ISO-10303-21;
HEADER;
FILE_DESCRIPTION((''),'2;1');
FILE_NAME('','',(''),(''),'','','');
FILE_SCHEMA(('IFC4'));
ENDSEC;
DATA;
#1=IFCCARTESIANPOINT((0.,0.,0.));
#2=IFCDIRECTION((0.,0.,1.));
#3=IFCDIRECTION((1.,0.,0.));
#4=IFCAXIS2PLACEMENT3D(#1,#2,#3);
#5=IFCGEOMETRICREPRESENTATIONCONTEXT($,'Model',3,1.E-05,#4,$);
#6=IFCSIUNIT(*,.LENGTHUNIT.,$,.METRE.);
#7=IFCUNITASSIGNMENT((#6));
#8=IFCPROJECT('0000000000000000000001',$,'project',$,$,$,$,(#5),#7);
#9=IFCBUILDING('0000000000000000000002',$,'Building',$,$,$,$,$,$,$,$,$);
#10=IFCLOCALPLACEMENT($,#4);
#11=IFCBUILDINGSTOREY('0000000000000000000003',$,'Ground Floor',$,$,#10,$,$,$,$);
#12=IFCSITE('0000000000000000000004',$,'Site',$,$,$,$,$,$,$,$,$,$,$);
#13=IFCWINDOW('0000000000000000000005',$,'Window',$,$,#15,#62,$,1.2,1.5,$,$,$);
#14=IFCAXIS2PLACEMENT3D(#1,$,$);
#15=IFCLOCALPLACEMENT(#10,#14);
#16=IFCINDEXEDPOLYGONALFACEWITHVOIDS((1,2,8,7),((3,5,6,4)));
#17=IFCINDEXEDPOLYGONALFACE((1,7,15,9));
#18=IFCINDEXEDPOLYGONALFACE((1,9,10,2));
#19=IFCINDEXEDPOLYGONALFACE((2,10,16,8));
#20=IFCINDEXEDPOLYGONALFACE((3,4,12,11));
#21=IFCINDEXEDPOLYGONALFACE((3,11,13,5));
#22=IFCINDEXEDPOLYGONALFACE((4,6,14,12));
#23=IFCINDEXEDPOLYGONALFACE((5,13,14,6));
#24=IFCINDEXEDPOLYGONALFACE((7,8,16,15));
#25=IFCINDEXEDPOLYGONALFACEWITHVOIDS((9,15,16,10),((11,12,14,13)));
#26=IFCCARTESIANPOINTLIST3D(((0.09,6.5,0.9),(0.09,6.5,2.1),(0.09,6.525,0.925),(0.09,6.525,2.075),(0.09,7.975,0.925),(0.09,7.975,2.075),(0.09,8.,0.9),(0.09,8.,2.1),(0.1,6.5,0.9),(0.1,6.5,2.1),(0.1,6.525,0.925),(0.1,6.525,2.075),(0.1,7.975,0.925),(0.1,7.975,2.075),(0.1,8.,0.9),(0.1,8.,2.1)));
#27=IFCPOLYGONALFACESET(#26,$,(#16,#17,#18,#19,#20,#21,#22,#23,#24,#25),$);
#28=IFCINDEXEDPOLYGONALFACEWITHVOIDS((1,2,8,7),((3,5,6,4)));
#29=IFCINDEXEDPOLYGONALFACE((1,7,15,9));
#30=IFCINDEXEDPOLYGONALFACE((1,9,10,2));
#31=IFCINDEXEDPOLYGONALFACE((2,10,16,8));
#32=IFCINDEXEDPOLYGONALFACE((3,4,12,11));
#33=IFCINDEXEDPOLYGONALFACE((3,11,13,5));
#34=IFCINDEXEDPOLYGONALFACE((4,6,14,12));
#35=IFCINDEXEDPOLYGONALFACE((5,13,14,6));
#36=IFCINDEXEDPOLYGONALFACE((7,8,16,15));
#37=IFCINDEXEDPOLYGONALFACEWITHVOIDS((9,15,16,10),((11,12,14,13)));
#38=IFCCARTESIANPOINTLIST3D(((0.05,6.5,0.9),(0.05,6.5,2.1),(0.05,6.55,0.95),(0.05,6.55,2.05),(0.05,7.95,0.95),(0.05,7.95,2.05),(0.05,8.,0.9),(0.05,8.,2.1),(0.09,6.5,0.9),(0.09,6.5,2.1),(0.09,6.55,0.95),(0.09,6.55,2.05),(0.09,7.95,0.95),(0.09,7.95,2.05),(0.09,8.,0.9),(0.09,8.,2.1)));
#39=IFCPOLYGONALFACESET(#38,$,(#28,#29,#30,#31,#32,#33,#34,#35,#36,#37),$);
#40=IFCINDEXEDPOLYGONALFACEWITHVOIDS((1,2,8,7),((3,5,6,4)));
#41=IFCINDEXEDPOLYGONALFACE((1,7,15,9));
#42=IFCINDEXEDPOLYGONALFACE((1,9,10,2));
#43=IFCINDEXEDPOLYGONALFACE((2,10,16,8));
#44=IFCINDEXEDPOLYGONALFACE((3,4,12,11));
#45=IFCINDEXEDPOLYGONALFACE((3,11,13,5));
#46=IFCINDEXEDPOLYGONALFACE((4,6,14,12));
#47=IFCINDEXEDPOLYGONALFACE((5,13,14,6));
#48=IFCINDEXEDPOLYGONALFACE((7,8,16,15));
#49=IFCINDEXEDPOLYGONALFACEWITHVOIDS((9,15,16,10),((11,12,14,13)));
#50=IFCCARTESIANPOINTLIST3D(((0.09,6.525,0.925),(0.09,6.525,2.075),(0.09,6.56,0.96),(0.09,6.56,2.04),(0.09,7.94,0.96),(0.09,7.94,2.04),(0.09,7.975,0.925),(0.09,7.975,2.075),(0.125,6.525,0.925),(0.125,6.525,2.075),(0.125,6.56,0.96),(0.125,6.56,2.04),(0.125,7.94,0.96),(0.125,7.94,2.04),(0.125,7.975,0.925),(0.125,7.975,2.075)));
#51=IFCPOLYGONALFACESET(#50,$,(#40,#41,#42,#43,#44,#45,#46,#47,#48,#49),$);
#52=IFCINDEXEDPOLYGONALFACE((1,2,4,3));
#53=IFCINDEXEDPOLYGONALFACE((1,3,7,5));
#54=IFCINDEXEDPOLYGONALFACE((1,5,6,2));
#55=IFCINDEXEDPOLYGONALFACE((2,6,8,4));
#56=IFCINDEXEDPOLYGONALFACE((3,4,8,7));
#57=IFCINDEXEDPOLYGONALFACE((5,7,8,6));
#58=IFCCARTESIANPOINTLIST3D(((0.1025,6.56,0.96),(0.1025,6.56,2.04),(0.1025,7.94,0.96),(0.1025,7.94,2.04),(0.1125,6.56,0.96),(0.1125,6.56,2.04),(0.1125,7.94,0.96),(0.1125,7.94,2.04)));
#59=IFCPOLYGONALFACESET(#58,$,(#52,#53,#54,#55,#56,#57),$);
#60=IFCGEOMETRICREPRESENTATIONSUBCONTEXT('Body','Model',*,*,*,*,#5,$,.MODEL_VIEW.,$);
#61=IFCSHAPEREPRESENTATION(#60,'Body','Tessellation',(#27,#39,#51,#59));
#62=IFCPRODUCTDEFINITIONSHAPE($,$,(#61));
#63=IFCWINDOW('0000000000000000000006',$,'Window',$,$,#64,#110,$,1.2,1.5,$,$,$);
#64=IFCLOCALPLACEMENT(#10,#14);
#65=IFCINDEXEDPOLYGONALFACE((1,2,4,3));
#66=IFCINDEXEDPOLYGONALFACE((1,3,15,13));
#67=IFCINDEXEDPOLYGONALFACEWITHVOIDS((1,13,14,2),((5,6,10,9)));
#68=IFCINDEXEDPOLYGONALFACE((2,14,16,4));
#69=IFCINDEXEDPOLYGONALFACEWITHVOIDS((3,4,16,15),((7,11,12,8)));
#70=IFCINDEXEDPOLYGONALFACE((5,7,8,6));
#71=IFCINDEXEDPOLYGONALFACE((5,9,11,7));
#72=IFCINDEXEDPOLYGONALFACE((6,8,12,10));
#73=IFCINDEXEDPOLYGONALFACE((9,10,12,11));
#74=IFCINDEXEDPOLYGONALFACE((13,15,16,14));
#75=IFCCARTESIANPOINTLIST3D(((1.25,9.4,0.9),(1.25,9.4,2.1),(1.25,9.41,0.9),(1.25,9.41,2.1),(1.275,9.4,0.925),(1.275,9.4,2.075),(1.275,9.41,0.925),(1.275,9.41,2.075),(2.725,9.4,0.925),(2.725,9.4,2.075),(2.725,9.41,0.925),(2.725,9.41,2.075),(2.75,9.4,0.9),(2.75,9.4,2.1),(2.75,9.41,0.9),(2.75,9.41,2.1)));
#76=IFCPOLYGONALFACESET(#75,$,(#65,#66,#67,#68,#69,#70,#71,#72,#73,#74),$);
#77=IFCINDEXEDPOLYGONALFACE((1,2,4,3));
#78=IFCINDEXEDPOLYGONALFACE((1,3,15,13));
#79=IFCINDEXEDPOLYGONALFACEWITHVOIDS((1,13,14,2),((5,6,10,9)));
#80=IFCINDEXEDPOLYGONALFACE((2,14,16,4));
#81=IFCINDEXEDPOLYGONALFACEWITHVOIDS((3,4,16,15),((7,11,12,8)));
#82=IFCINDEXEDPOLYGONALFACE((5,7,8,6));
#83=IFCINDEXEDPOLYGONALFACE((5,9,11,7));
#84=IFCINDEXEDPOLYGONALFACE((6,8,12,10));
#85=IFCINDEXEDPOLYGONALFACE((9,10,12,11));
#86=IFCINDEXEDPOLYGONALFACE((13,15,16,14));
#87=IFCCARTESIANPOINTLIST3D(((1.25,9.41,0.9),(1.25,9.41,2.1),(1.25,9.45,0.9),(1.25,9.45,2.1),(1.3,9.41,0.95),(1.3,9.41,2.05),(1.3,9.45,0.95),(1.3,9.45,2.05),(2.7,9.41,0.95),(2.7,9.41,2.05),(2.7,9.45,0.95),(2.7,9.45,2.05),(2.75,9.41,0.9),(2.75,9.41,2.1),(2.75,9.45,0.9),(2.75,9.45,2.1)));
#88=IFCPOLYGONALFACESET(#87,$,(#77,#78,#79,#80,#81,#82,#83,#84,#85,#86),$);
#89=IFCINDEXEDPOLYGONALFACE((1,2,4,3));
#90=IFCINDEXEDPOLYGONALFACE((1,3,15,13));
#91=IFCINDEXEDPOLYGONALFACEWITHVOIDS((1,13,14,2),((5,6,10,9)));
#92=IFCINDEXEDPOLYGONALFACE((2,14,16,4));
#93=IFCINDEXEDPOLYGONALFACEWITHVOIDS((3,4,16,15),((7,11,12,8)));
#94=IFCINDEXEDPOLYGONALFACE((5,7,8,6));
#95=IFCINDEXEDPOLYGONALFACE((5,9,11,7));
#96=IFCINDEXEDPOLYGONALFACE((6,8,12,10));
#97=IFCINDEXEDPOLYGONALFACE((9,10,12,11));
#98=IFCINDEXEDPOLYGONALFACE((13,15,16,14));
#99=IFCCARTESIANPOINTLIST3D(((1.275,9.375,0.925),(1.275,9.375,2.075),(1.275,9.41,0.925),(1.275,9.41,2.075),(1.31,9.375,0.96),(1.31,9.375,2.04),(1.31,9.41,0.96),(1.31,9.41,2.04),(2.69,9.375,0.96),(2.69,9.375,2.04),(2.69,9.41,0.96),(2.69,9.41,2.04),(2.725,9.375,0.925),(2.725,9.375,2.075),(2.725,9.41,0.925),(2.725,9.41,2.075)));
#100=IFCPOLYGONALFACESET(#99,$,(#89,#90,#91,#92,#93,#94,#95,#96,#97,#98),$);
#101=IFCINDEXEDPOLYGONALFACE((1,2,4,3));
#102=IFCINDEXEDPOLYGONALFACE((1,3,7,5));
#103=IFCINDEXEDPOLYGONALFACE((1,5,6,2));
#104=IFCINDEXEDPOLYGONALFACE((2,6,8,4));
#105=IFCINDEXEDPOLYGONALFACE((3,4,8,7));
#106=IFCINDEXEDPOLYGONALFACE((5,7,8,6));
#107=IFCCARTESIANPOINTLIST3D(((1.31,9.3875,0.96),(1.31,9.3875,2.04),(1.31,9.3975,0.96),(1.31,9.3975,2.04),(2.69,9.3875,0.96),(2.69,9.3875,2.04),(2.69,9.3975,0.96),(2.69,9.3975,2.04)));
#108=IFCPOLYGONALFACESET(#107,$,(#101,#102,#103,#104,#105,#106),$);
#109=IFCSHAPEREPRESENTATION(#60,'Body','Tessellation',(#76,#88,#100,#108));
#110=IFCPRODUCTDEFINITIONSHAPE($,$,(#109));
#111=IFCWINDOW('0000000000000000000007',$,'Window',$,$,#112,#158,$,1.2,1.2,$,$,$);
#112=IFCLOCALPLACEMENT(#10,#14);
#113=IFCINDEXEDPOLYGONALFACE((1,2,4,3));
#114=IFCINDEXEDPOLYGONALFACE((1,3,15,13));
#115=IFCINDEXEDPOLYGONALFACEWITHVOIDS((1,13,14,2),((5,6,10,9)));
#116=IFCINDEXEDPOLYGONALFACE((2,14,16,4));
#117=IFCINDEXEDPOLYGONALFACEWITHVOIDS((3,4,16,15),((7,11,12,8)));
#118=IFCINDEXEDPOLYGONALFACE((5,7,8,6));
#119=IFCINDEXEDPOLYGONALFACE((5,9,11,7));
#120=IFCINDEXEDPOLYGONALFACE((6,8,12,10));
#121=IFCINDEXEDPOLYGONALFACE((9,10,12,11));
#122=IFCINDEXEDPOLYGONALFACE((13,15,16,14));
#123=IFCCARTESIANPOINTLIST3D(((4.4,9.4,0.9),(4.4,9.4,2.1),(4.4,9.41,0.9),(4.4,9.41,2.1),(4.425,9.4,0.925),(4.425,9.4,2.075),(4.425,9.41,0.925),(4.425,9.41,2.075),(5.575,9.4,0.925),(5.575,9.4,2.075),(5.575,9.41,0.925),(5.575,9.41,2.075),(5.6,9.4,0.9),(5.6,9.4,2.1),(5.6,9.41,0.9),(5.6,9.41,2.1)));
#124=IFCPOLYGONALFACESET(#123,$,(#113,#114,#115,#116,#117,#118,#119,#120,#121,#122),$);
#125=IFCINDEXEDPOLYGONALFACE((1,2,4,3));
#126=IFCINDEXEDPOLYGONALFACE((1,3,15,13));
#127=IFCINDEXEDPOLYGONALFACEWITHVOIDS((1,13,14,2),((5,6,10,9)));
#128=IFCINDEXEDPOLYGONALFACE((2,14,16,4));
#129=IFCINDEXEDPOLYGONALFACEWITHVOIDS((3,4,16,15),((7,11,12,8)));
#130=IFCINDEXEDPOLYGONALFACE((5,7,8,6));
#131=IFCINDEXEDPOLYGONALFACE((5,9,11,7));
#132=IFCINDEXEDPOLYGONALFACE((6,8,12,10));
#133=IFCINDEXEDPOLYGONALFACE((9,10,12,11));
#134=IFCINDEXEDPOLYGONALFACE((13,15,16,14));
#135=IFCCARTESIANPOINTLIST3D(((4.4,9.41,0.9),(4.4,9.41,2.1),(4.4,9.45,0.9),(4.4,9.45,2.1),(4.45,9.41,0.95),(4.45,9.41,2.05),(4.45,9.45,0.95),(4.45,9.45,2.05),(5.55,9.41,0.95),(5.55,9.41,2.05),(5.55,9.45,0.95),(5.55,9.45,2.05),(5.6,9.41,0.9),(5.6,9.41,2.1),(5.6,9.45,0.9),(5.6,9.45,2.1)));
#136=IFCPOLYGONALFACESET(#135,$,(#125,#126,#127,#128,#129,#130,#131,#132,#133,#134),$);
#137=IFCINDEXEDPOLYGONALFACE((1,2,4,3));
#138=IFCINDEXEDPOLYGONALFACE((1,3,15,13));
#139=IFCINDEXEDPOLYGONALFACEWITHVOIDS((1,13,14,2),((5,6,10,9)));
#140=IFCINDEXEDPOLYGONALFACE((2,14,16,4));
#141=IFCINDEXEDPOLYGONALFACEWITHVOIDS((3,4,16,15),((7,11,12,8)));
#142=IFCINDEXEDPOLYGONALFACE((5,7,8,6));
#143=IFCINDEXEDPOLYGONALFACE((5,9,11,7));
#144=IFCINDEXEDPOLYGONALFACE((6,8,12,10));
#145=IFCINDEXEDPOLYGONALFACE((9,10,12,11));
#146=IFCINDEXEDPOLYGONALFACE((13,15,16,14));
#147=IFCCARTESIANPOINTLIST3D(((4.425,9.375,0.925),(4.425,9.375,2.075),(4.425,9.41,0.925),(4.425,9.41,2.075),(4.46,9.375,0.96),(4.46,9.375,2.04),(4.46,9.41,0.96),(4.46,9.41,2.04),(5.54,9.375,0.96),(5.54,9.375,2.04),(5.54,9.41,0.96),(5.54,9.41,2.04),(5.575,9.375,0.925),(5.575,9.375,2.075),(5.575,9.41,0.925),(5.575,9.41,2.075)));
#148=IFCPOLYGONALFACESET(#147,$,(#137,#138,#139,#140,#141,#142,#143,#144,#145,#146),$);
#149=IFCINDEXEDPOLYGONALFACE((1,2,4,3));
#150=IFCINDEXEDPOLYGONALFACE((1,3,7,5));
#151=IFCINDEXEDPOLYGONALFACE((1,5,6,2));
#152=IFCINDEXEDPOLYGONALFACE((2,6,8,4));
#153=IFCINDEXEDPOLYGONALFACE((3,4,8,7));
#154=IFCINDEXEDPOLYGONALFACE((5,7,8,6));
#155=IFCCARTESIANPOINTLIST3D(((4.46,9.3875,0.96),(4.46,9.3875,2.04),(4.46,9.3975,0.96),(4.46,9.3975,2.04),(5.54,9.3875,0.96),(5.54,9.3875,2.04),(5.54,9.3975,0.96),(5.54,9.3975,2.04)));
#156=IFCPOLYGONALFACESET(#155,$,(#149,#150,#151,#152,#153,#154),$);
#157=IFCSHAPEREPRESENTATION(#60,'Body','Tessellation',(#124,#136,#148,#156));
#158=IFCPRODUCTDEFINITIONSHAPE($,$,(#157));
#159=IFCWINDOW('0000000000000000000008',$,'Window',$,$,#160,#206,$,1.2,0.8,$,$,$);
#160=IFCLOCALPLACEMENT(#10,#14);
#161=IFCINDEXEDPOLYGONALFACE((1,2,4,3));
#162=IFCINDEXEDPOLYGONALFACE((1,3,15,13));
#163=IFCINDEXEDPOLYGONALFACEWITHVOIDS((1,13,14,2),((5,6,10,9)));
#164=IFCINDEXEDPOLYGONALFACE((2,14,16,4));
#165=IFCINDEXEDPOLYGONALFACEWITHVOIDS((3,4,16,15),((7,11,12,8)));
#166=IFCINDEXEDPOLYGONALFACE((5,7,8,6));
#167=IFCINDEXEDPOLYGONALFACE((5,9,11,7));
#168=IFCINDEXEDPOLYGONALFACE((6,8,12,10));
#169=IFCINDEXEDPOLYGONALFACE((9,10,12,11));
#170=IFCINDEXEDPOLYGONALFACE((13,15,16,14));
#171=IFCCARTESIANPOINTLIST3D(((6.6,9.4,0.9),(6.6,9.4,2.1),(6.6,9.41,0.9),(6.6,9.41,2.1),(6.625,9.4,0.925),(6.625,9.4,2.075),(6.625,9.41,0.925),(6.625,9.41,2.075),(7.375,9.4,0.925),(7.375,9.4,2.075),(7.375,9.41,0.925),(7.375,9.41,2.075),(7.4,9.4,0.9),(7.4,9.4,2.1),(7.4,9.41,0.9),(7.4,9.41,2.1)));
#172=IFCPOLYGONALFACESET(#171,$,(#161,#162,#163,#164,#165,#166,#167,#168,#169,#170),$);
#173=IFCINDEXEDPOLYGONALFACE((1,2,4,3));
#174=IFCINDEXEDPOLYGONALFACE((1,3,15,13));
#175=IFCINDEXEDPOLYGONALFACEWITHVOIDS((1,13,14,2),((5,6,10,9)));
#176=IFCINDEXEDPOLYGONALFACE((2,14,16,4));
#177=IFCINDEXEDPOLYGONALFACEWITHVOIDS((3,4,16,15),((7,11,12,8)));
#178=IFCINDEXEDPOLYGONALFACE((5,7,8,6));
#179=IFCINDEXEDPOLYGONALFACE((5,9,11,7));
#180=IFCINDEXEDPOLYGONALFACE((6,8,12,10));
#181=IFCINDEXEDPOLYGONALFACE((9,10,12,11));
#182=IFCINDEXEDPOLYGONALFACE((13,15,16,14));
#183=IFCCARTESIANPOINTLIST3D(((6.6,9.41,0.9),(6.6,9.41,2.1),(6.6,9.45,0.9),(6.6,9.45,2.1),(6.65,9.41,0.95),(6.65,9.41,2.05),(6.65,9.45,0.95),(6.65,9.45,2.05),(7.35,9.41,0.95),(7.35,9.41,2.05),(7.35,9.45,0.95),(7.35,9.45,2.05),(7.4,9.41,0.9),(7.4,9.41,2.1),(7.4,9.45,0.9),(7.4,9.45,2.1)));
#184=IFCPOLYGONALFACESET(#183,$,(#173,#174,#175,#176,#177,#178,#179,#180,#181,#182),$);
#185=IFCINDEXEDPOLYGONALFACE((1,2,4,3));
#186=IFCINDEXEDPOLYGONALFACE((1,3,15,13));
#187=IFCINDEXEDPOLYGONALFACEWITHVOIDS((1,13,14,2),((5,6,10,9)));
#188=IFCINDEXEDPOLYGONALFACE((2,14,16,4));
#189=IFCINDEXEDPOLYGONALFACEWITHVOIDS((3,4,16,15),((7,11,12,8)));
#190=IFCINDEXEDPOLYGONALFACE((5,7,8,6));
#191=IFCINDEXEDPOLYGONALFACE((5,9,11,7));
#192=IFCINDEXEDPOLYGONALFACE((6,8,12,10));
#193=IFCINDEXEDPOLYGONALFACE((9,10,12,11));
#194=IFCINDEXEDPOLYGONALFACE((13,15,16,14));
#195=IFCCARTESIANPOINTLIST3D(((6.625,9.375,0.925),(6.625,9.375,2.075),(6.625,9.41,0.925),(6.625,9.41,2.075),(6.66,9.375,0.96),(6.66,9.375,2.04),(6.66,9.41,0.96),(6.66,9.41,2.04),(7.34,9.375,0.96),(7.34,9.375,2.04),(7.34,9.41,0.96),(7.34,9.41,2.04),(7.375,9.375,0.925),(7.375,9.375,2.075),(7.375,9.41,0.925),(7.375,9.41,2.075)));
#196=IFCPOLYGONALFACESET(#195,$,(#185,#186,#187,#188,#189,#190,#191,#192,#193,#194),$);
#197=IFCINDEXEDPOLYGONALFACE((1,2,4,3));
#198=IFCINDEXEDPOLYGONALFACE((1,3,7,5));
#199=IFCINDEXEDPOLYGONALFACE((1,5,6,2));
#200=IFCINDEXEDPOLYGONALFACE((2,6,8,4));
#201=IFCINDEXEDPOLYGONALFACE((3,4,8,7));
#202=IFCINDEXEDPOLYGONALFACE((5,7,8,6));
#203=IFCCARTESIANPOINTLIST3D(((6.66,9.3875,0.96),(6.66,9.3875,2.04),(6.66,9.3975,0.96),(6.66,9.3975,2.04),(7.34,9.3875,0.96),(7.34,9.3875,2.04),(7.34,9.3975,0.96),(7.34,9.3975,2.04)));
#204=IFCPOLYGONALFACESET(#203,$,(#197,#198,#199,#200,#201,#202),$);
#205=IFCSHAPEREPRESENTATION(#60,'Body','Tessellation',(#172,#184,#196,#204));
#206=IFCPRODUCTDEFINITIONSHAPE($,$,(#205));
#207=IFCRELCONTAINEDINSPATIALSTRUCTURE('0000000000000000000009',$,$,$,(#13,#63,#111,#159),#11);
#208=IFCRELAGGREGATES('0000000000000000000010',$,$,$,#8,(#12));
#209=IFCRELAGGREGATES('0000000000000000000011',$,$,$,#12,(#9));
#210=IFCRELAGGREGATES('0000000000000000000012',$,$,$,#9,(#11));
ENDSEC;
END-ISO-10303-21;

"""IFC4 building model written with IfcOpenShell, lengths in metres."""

from ifc_helpers import new_model, si_unit, frame, origin_with_axes, place, context, subcontext, project, spatial, line, indexed_curve, outline, extrude, element, save


model = new_model("IFC4")

# Units and contexts
model_context = context("Model", 3, precision=1e-05, world=origin_with_axes())
body_context = subcontext(model_context, "Body", "Model", "MODEL_VIEW")
ifc_project = project(units=[si_unit("LENGTHUNIT", "METRE")], contexts=[model_context])

# Site, building, storey
site = spatial("IfcSite", under=ifc_project, Name="Site")
building = spatial("IfcBuilding", under=site, Name="Building")
storey_placement = place(None, origin_with_axes())
storey = spatial("IfcBuildingStorey", under=building, at=storey_placement, Name="Ground Floor")

# Windows
for number, where, z_axis, x_axis, name in (
    (1, (0.0, 8.0, 0.9), (0.0, 0.0, 1.0), (0.0, -1.0, 0.0), "Window"),
    (2, (2.75, 9.5, 0.9), (0.0, 0.0, 1.0), (-1.0, 0.0, 0.0), "Window"),
):
    element("IfcWindow", number, at=place(storey_placement, frame(where, z_axis=z_axis, x_axis=x_axis)), inside=storey, Name=name, OverallHeight=1.2, OverallWidth=1.5, context=body_context, shape_type="SweptSolid", body=[
        extrude(outline(indexed_curve([(0.0, 0.0), (1.5, 0.0), (1.5, 1.2), (0.0, 1.2)], segments=[line(1, 2, 3, 4, 1)]), holes=[indexed_curve([(0.025, 0.025), (1.475, 0.025), (1.475, 1.175), (0.025, 1.175)], segments=[line(1, 2, 3, 4, 1)])]), frame((0.0, 0.09, 0.0), z_axis=(0.0, -1.0, 0.0), x_axis=(1.0, 0.0, 0.0)), (0.0, 0.0, -1.0), 0.01),
        extrude(outline(indexed_curve([(0.0, 0.0), (1.5, 0.0), (1.5, 1.2), (0.0, 1.2)], segments=[line(1, 2, 3, 4, 1)]), holes=[indexed_curve([(0.05, 0.05), (1.45, 0.05), (1.45, 1.15), (0.05, 1.15)], segments=[line(1, 2, 3, 4, 1)])]), frame((0.0, 0.05, 0.0), z_axis=(0.0, -1.0, 0.0), x_axis=(1.0, 0.0, 0.0)), (0.0, 0.0, -1.0), 0.04),
        extrude(outline(indexed_curve([(0.0, 0.0), (1.45, 0.0), (1.45, 1.15), (0.0, 1.15)], segments=[line(1, 2, 3, 4, 1)]), holes=[indexed_curve([(0.035, 0.035), (1.415, 0.035), (1.415, 1.115), (0.035, 1.115)], segments=[line(1, 2, 3, 4, 1)])]), frame((0.025, 0.09, 0.025), z_axis=(0.0, -1.0, 0.0), x_axis=(1.0, 0.0, 0.0)), (0.0, 0.0, -1.0), 0.035),
        extrude(outline(indexed_curve([(0.035, 0.035), (1.415, 0.035), (1.415, 1.115), (0.035, 1.115)], segments=[line(1, 2, 3, 4, 1)])), frame((0.025, 0.1025, 0.025), z_axis=(0.0, -1.0, 0.0), x_axis=(1.0, 0.0, 0.0)), (0.0, 0.0, -1.0), 0.01),
    ])
window_1_placement = place(storey_placement, frame((5.6, 9.5, 0.9), z_axis=(0.0, 0.0, 1.0), x_axis=(-1.0, 0.0, 0.0)))
element("IfcWindow", 3, at=window_1_placement, inside=storey, Name="Window", OverallHeight=1.2, OverallWidth=1.2, context=body_context, shape_type="SweptSolid", body=[
    extrude(outline(indexed_curve([(0.0, 0.0), (1.2, 0.0), (1.2, 1.2), (0.0, 1.2)], segments=[line(1, 2, 3, 4, 1)]), holes=[indexed_curve([(0.025, 0.025), (1.175, 0.025), (1.175, 1.175), (0.025, 1.175)], segments=[line(1, 2, 3, 4, 1)])]), frame((0.0, 0.09, 0.0), z_axis=(0.0, -1.0, 0.0), x_axis=(1.0, 0.0, 0.0)), (0.0, 0.0, -1.0), 0.01),
    extrude(outline(indexed_curve([(0.0, 0.0), (1.2, 0.0), (1.2, 1.2), (0.0, 1.2)], segments=[line(1, 2, 3, 4, 1)]), holes=[indexed_curve([(0.05, 0.05), (1.15, 0.05), (1.15, 1.15), (0.05, 1.15)], segments=[line(1, 2, 3, 4, 1)])]), frame((0.0, 0.05, 0.0), z_axis=(0.0, -1.0, 0.0), x_axis=(1.0, 0.0, 0.0)), (0.0, 0.0, -1.0), 0.04),
    extrude(outline(indexed_curve([(0.0, 0.0), (1.15, 0.0), (1.15, 1.15), (0.0, 1.15)], segments=[line(1, 2, 3, 4, 1)]), holes=[indexed_curve([(0.035, 0.035), (1.115, 0.035), (1.115, 1.115), (0.035, 1.115)], segments=[line(1, 2, 3, 4, 1)])]), frame((0.025, 0.09, 0.025), z_axis=(0.0, -1.0, 0.0), x_axis=(1.0, 0.0, 0.0)), (0.0, 0.0, -1.0), 0.035),
    extrude(outline(indexed_curve([(0.035, 0.035), (1.115, 0.035), (1.115, 1.115), (0.035, 1.115)], segments=[line(1, 2, 3, 4, 1)])), frame((0.025, 0.1025, 0.025), z_axis=(0.0, -1.0, 0.0), x_axis=(1.0, 0.0, 0.0)), (0.0, 0.0, -1.0), 0.01),
])
window_2_placement = place(storey_placement, frame((7.4, 9.5, 0.9), z_axis=(0.0, 0.0, 1.0), x_axis=(-1.0, 0.0, 0.0)))
element("IfcWindow", 4, at=window_2_placement, inside=storey, Name="Window", OverallHeight=1.2, OverallWidth=0.8, context=body_context, shape_type="SweptSolid", body=[
    extrude(outline(indexed_curve([(0.0, 0.0), (0.8, 0.0), (0.8, 1.2), (0.0, 1.2)], segments=[line(1, 2, 3, 4, 1)]), holes=[indexed_curve([(0.025, 0.025), (0.775, 0.025), (0.775, 1.175), (0.025, 1.175)], segments=[line(1, 2, 3, 4, 1)])]), frame((0.0, 0.09, 0.0), z_axis=(0.0, -1.0, 0.0), x_axis=(1.0, 0.0, 0.0)), (0.0, 0.0, -1.0), 0.01),
    extrude(outline(indexed_curve([(0.0, 0.0), (0.8, 0.0), (0.8, 1.2), (0.0, 1.2)], segments=[line(1, 2, 3, 4, 1)]), holes=[indexed_curve([(0.05, 0.05), (0.75, 0.05), (0.75, 1.15), (0.05, 1.15)], segments=[line(1, 2, 3, 4, 1)])]), frame((0.0, 0.05, 0.0), z_axis=(0.0, -1.0, 0.0), x_axis=(1.0, 0.0, 0.0)), (0.0, 0.0, -1.0), 0.04),
    extrude(outline(indexed_curve([(0.0, 0.0), (0.75, 0.0), (0.75, 1.15), (0.0, 1.15)], segments=[line(1, 2, 3, 4, 1)]), holes=[indexed_curve([(0.035, 0.035), (0.715, 0.035), (0.715, 1.115), (0.035, 1.115)], segments=[line(1, 2, 3, 4, 1)])]), frame((0.025, 0.09, 0.025), z_axis=(0.0, -1.0, 0.0), x_axis=(1.0, 0.0, 0.0)), (0.0, 0.0, -1.0), 0.035),
    extrude(outline(indexed_curve([(0.035, 0.035), (0.715, 0.035), (0.715, 1.115), (0.035, 1.115)], segments=[line(1, 2, 3, 4, 1)])), frame((0.025, 0.1025, 0.025), z_axis=(0.0, -1.0, 0.0), x_axis=(1.0, 0.0, 0.0)), (0.0, 0.0, -1.0), 0.01),
])

save(model, "model.ifc")
